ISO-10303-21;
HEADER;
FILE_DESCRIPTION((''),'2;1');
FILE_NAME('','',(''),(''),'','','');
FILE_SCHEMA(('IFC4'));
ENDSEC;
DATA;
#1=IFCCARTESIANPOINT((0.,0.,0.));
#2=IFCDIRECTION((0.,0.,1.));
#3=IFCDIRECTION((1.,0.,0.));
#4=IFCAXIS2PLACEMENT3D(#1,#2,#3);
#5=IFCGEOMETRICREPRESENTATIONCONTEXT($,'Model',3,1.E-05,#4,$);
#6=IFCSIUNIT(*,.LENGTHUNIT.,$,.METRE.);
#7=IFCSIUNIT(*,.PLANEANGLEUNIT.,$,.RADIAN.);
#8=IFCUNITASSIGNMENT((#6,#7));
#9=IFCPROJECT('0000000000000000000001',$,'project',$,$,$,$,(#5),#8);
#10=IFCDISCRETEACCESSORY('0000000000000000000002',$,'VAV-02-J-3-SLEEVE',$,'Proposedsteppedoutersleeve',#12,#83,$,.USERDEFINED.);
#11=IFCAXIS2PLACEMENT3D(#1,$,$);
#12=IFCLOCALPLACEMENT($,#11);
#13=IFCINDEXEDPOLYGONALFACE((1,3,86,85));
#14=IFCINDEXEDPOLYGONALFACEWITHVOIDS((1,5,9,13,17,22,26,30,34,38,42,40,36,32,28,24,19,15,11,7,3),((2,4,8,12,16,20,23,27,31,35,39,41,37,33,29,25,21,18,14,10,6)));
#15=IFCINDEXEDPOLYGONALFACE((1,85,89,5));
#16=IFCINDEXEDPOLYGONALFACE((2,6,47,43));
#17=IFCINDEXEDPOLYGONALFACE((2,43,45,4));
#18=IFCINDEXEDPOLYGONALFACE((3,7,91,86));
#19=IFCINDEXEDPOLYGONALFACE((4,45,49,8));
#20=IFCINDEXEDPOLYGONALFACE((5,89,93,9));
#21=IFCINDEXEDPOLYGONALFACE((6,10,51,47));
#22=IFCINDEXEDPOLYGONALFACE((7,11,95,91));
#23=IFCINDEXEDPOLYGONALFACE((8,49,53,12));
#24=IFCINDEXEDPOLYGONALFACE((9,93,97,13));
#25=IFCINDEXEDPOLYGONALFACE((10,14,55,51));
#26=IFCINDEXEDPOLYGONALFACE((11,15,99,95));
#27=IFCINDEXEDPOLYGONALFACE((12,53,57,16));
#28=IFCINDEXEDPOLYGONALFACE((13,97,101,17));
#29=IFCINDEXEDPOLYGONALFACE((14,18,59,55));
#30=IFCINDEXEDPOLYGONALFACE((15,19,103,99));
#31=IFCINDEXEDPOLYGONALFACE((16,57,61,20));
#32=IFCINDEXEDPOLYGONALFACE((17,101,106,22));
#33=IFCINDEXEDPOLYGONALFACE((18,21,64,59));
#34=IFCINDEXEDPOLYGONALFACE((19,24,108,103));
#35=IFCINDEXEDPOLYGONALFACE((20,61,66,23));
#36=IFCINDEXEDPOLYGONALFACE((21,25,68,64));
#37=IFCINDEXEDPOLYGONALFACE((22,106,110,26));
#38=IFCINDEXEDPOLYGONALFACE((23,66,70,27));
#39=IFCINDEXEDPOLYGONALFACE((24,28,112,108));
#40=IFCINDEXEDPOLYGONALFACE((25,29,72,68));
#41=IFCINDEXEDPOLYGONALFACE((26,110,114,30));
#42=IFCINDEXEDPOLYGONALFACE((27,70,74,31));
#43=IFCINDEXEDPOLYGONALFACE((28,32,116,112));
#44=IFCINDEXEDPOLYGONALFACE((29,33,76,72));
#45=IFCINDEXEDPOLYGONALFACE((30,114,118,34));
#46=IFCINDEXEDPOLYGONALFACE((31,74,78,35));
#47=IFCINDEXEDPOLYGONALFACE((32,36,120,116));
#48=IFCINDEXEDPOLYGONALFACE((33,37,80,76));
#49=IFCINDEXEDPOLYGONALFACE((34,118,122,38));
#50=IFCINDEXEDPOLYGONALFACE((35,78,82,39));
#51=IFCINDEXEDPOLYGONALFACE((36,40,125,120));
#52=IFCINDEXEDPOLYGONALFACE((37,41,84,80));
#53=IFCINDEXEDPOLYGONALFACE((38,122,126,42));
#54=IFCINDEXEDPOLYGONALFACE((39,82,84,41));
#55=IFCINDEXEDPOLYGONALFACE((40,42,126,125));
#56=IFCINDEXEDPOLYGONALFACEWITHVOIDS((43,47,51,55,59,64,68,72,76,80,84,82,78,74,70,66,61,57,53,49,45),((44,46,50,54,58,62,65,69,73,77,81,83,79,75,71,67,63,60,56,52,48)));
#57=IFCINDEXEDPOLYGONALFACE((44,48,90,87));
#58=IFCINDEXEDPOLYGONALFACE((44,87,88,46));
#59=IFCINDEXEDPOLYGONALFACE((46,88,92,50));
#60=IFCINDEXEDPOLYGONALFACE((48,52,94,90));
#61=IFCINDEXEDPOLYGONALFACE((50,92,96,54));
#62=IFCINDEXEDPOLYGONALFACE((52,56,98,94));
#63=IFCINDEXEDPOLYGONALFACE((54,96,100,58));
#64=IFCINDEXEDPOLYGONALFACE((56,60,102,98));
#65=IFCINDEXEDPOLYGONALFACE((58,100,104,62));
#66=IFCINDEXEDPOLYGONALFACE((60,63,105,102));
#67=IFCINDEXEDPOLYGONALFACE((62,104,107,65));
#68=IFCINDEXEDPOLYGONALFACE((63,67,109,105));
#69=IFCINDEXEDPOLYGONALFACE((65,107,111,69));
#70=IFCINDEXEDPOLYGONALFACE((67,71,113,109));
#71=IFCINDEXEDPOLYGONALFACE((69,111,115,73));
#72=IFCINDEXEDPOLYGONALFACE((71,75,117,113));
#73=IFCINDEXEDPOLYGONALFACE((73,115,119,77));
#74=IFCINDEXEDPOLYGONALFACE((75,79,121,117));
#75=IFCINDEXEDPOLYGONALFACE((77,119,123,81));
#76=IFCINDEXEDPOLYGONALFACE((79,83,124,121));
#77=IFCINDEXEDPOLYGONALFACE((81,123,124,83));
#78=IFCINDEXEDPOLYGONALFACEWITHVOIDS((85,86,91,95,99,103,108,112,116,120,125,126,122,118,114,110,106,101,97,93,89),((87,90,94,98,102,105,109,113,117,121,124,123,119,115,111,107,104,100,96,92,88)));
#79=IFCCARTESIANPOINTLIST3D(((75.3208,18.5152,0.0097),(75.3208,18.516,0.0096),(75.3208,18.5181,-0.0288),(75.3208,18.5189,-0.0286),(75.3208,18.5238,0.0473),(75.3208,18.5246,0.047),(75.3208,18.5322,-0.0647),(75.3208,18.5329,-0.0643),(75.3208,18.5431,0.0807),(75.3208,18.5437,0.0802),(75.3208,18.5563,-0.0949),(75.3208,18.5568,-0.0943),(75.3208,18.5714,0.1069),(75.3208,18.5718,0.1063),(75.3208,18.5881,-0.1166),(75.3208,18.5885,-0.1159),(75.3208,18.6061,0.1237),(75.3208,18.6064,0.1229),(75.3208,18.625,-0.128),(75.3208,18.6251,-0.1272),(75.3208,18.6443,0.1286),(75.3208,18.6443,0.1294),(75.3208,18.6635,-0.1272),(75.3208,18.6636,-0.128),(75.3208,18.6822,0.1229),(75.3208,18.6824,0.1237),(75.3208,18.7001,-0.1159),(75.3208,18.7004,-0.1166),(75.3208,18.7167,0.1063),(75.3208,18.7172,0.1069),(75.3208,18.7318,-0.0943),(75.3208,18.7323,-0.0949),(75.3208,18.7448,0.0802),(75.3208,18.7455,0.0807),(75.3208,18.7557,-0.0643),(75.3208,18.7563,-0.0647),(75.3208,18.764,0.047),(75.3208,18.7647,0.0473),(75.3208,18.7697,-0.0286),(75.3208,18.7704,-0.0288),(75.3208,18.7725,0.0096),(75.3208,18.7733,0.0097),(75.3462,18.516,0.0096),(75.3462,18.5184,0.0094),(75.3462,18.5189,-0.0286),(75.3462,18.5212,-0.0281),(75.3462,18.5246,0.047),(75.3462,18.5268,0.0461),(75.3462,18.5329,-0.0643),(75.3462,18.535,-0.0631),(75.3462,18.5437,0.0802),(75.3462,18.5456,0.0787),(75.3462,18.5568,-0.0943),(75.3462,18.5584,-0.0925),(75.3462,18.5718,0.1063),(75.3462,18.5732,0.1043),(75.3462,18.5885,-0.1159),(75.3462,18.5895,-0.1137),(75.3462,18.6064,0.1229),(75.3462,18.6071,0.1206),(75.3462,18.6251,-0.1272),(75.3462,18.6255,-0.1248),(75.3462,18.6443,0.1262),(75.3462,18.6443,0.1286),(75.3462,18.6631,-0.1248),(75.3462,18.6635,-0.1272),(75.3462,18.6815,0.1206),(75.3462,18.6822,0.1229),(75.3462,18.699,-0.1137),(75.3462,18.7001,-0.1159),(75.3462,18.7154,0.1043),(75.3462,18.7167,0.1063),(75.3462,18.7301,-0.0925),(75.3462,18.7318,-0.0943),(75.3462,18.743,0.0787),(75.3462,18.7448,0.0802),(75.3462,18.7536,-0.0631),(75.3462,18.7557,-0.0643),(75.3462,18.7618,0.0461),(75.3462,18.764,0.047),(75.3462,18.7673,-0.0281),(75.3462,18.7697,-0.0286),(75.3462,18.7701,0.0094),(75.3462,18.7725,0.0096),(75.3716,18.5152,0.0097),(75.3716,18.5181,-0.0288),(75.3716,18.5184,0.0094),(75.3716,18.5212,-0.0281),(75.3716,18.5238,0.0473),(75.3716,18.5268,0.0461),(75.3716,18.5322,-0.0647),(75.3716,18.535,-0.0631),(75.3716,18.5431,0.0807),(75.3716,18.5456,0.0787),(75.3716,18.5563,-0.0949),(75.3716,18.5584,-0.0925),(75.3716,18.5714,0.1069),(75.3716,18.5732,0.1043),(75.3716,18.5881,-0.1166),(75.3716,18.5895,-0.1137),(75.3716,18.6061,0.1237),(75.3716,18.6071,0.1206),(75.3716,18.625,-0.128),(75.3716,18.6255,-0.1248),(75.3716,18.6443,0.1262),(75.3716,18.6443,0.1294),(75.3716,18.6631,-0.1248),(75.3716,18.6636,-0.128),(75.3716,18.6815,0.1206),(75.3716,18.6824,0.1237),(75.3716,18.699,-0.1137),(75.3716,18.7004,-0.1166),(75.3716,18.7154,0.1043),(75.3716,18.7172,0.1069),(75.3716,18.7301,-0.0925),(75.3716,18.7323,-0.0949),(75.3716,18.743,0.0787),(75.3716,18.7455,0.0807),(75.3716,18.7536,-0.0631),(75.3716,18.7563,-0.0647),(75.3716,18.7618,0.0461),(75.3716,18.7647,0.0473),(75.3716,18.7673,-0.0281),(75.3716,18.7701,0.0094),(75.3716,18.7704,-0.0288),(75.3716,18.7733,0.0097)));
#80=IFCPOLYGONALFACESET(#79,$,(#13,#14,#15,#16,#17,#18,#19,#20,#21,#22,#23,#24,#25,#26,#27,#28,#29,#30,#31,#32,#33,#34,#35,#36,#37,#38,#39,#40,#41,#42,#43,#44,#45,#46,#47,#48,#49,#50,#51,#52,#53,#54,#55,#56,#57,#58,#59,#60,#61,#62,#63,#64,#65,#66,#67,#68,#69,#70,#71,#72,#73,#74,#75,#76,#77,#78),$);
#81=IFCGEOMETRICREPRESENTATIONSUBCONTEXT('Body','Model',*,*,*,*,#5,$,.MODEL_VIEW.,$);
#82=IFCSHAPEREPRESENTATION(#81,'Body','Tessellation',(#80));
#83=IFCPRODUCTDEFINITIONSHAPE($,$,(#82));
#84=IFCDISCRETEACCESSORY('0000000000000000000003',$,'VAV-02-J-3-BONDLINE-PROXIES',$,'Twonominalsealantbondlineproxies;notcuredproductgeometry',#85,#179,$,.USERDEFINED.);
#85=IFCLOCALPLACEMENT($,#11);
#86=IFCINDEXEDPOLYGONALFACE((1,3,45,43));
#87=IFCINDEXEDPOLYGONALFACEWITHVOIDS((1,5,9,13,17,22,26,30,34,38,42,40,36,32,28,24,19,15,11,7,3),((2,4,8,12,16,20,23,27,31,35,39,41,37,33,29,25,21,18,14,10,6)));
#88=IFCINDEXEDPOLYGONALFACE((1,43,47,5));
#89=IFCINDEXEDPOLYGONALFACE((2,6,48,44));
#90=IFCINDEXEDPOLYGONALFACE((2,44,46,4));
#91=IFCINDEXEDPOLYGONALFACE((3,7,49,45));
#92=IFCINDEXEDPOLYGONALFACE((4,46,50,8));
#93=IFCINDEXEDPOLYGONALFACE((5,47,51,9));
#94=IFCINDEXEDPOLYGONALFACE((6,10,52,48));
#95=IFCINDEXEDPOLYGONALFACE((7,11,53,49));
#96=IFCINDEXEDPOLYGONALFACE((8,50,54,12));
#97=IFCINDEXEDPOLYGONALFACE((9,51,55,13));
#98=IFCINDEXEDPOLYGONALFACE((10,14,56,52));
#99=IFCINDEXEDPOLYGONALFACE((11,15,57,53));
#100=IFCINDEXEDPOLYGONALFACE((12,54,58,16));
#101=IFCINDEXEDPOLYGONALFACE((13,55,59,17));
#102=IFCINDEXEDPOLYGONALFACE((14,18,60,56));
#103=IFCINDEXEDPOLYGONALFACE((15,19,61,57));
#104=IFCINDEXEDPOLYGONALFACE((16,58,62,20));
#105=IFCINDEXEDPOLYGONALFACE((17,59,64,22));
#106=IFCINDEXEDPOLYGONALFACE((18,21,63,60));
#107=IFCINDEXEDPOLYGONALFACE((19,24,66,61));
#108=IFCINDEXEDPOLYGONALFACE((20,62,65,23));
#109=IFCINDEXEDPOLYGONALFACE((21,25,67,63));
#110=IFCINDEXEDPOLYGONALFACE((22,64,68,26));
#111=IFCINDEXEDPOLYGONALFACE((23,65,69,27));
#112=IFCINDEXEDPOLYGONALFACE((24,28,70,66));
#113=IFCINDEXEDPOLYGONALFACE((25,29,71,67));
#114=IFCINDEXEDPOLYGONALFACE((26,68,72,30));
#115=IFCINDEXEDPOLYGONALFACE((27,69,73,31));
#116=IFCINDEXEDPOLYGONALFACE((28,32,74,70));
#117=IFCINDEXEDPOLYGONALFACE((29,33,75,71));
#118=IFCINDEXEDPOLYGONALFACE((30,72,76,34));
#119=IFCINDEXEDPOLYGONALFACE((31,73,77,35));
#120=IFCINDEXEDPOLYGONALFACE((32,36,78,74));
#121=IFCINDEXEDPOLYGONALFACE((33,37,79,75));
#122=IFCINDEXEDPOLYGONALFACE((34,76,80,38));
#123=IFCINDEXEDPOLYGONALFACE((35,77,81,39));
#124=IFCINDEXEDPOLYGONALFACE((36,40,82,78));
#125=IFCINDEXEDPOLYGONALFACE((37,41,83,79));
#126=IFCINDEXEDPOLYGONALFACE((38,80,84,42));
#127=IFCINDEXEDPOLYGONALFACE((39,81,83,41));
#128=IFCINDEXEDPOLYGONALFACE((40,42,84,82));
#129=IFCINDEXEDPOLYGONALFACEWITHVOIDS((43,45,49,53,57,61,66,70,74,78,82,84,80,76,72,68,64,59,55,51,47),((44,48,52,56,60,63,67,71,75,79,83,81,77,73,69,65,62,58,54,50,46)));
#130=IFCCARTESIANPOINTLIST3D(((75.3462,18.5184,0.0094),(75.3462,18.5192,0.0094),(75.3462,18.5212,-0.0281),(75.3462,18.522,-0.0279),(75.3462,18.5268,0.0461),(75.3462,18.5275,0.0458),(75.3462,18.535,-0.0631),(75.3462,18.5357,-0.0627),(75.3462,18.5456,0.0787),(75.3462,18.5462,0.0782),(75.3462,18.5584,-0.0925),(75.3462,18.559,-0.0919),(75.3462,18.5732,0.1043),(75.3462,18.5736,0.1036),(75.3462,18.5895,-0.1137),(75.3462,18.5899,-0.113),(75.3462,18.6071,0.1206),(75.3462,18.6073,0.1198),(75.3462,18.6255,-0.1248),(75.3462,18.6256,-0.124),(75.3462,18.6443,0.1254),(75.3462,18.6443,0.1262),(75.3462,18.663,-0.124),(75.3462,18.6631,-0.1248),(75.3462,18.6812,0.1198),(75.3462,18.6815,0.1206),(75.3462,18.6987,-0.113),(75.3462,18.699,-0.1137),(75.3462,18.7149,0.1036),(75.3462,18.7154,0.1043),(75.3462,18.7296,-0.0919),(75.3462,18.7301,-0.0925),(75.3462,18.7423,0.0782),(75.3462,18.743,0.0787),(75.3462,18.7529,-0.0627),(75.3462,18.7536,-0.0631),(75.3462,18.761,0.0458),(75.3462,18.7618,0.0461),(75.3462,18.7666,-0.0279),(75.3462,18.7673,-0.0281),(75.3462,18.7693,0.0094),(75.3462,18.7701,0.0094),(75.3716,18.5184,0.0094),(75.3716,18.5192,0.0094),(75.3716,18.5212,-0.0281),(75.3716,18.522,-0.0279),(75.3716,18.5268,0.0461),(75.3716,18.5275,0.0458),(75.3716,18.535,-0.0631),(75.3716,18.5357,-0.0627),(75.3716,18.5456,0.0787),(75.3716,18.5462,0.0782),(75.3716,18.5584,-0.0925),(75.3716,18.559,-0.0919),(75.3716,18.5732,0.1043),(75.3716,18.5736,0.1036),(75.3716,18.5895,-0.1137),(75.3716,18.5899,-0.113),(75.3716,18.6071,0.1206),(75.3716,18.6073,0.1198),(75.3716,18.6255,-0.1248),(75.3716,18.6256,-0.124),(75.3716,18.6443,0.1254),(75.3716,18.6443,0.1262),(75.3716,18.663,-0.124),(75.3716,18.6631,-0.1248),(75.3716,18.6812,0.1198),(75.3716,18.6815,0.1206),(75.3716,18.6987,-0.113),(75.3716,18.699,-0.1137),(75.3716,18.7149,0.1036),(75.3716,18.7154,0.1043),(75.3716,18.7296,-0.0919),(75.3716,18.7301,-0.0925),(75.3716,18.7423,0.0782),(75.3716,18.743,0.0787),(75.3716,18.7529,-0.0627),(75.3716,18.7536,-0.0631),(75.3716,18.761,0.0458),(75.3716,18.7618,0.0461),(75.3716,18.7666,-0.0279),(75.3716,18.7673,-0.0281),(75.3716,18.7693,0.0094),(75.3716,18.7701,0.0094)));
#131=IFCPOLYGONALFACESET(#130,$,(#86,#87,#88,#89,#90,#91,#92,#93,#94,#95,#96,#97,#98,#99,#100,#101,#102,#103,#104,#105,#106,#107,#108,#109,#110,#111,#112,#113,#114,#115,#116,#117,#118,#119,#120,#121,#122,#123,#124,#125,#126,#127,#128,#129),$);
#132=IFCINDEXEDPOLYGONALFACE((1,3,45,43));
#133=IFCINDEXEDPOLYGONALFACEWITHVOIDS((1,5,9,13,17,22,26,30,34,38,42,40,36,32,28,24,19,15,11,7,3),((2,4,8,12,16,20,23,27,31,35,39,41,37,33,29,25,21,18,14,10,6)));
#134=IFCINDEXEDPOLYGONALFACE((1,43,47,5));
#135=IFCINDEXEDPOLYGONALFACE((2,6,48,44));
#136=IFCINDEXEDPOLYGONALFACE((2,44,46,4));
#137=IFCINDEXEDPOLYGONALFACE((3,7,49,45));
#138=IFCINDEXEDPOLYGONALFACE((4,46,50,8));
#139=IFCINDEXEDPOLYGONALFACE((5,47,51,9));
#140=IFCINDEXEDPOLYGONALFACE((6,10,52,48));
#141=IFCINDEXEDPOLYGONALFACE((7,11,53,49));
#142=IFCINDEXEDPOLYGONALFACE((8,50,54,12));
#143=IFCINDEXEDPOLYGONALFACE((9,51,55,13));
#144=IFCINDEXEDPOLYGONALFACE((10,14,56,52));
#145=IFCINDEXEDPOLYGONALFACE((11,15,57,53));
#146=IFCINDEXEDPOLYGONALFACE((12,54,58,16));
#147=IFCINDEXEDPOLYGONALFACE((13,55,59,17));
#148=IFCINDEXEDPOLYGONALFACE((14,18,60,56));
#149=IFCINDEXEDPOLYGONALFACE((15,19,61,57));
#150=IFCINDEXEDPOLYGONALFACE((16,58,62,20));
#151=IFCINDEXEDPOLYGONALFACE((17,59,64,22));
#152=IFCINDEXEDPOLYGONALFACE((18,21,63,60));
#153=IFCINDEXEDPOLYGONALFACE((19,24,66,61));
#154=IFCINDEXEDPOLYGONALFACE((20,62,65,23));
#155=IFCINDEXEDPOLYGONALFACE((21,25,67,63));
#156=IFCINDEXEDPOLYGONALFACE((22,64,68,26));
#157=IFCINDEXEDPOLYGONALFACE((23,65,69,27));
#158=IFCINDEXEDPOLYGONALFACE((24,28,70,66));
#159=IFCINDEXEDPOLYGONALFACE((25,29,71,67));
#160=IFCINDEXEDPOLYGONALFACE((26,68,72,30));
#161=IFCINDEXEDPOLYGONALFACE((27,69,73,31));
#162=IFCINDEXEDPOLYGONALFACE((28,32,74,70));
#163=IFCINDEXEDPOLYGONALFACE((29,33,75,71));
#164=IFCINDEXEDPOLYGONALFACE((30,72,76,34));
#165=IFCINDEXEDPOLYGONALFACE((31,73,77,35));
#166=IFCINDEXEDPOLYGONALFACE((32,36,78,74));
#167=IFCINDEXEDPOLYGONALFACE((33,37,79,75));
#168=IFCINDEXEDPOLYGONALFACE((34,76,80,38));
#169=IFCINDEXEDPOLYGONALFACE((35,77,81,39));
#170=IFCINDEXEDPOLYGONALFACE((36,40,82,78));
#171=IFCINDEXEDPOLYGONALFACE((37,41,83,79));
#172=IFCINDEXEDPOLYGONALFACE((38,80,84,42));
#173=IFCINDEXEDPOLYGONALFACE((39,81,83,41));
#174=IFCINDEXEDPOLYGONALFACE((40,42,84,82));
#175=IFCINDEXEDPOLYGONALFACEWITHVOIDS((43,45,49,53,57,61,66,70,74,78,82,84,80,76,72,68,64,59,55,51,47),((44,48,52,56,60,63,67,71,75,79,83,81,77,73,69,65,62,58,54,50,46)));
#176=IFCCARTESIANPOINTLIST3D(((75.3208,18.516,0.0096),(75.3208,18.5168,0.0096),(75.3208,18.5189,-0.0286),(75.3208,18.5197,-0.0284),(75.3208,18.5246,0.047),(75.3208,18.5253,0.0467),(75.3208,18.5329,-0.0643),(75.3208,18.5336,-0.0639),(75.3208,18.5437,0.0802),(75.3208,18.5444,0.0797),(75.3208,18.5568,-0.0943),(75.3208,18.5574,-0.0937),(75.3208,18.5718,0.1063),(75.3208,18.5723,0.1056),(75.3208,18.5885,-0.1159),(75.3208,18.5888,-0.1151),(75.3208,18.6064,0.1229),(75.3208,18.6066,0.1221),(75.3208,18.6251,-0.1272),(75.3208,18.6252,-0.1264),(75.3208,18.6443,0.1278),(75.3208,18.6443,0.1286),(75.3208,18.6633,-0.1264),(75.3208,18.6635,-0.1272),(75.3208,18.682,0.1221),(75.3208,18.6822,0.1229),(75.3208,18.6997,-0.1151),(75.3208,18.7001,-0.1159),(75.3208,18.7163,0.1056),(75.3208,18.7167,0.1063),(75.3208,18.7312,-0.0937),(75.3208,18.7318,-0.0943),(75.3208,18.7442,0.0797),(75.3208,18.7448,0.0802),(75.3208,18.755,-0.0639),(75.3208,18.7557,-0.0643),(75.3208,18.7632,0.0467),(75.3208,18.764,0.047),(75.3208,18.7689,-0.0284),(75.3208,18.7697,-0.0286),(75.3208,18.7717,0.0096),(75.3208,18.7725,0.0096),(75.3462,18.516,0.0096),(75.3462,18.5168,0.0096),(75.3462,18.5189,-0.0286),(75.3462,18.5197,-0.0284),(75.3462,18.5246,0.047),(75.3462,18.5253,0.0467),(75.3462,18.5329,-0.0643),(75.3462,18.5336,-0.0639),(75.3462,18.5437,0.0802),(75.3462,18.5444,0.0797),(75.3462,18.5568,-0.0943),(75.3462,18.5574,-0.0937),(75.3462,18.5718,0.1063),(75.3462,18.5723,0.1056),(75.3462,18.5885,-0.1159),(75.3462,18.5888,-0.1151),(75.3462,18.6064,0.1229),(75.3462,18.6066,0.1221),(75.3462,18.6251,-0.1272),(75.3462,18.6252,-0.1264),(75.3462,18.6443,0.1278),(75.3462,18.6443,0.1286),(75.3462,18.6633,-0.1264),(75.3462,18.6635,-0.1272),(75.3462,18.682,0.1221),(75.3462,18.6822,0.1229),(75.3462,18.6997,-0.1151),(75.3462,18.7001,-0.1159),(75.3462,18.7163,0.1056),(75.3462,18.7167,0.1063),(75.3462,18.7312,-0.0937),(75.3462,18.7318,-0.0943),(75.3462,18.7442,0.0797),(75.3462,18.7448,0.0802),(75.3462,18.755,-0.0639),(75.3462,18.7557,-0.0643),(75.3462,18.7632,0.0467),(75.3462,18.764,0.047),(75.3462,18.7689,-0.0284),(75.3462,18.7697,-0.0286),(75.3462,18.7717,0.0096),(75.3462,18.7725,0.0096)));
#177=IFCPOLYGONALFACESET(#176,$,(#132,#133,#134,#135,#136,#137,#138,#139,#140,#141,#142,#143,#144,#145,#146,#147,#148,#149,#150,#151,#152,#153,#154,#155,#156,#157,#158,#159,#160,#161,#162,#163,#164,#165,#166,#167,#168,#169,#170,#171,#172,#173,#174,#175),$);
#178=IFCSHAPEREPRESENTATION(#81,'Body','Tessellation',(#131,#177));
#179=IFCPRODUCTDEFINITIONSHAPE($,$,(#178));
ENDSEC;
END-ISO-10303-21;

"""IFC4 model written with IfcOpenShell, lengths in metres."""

from ifc_helpers import new_model, entity, si_unit, frame, origin_with_axes, place, context, subcontext, project, element, save


model = new_model("IFC4")

# Units and contexts
model_context = context("Model", 3, precision=1e-05, world=origin_with_axes())
body_context = subcontext(model_context, "Body", "Model", "MODEL_VIEW")
ifc_project = project(units=[si_unit("LENGTHUNIT", "METRE"), si_unit("PLANEANGLEUNIT", "RADIAN")], contexts=[model_context])

# Discrete accessories
discrete_accessory_1_placement = place(None, frame((75.3462, 18.6443, 0.0), z_axis=(0.0, -1.0, 0.0), x_axis=(0.0, 0.0, 1.0)))
element("IfcDiscreteAccessory", 1, at=discrete_accessory_1_placement, Name="VAV-02-J-3-SLEEVE", ObjectType="Proposedsteppedoutersleeve", PredefinedType="USERDEFINED", context=body_context, shape_type="SweptSolid", body=[
    entity("IfcRevolvedAreaSolid", entity("IfcArbitraryClosedProfileDef", "AREA", None, entity("IfcPolyline", [entity("IfcCartesianPoint", [0.1262, -0.0254]), entity("IfcCartesianPoint", [0.1294, -0.0254]), entity("IfcCartesianPoint", [0.1294, 0.0254]), entity("IfcCartesianPoint", [0.1286, 0.0254]), entity("IfcCartesianPoint", [0.1286, 0.0]), entity("IfcCartesianPoint", [0.1262, 0.0]), entity("IfcCartesianPoint", [0.1262, -0.0254])])), entity("IfcAxis2Placement3D", entity("IfcCartesianPoint", [0.0, 0.0, 0.0])), entity("IfcAxis1Placement", entity("IfcCartesianPoint", [0.0, 0.0, 0.0]), entity("IfcDirection", [0.0, 1.0, 0.0])), 6.283185),
])
discrete_accessory_2_placement = place(None, frame((75.3462, 18.6443, 0.0), z_axis=(0.0, -1.0, 0.0), x_axis=(0.0, 0.0, 1.0)))
element("IfcDiscreteAccessory", 2, at=discrete_accessory_2_placement, Name="VAV-02-J-3-BONDLINE-PROXIES", ObjectType="Twonominalsealantbondlineproxies;notcuredproductgeometry", PredefinedType="USERDEFINED", context=body_context, shape_type="SweptSolid", body=[
    entity("IfcRevolvedAreaSolid", entity("IfcArbitraryClosedProfileDef", "AREA", None, entity("IfcPolyline", [entity("IfcCartesianPoint", [0.1254, -0.0254]), entity("IfcCartesianPoint", [0.1262, -0.0254]), entity("IfcCartesianPoint", [0.1262, 0.0]), entity("IfcCartesianPoint", [0.1254, 0.0]), entity("IfcCartesianPoint", [0.1254, -0.0254])])), entity("IfcAxis2Placement3D", entity("IfcCartesianPoint", [0.0, 0.0, 0.0])), entity("IfcAxis1Placement", entity("IfcCartesianPoint", [0.0, 0.0, 0.0]), entity("IfcDirection", [0.0, 1.0, 0.0])), 6.283185),
    entity("IfcRevolvedAreaSolid", entity("IfcArbitraryClosedProfileDef", "AREA", None, entity("IfcPolyline", [entity("IfcCartesianPoint", [0.1278, 0.0]), entity("IfcCartesianPoint", [0.1286, 0.0]), entity("IfcCartesianPoint", [0.1286, 0.0254]), entity("IfcCartesianPoint", [0.1278, 0.0254]), entity("IfcCartesianPoint", [0.1278, 0.0])])), entity("IfcAxis2Placement3D", entity("IfcCartesianPoint", [0.0, 0.0, 0.0])), entity("IfcAxis1Placement", entity("IfcCartesianPoint", [0.0, 0.0, 0.0]), entity("IfcDirection", [0.0, 1.0, 0.0])), 6.283185),
])

save(model, "model.ifc")
